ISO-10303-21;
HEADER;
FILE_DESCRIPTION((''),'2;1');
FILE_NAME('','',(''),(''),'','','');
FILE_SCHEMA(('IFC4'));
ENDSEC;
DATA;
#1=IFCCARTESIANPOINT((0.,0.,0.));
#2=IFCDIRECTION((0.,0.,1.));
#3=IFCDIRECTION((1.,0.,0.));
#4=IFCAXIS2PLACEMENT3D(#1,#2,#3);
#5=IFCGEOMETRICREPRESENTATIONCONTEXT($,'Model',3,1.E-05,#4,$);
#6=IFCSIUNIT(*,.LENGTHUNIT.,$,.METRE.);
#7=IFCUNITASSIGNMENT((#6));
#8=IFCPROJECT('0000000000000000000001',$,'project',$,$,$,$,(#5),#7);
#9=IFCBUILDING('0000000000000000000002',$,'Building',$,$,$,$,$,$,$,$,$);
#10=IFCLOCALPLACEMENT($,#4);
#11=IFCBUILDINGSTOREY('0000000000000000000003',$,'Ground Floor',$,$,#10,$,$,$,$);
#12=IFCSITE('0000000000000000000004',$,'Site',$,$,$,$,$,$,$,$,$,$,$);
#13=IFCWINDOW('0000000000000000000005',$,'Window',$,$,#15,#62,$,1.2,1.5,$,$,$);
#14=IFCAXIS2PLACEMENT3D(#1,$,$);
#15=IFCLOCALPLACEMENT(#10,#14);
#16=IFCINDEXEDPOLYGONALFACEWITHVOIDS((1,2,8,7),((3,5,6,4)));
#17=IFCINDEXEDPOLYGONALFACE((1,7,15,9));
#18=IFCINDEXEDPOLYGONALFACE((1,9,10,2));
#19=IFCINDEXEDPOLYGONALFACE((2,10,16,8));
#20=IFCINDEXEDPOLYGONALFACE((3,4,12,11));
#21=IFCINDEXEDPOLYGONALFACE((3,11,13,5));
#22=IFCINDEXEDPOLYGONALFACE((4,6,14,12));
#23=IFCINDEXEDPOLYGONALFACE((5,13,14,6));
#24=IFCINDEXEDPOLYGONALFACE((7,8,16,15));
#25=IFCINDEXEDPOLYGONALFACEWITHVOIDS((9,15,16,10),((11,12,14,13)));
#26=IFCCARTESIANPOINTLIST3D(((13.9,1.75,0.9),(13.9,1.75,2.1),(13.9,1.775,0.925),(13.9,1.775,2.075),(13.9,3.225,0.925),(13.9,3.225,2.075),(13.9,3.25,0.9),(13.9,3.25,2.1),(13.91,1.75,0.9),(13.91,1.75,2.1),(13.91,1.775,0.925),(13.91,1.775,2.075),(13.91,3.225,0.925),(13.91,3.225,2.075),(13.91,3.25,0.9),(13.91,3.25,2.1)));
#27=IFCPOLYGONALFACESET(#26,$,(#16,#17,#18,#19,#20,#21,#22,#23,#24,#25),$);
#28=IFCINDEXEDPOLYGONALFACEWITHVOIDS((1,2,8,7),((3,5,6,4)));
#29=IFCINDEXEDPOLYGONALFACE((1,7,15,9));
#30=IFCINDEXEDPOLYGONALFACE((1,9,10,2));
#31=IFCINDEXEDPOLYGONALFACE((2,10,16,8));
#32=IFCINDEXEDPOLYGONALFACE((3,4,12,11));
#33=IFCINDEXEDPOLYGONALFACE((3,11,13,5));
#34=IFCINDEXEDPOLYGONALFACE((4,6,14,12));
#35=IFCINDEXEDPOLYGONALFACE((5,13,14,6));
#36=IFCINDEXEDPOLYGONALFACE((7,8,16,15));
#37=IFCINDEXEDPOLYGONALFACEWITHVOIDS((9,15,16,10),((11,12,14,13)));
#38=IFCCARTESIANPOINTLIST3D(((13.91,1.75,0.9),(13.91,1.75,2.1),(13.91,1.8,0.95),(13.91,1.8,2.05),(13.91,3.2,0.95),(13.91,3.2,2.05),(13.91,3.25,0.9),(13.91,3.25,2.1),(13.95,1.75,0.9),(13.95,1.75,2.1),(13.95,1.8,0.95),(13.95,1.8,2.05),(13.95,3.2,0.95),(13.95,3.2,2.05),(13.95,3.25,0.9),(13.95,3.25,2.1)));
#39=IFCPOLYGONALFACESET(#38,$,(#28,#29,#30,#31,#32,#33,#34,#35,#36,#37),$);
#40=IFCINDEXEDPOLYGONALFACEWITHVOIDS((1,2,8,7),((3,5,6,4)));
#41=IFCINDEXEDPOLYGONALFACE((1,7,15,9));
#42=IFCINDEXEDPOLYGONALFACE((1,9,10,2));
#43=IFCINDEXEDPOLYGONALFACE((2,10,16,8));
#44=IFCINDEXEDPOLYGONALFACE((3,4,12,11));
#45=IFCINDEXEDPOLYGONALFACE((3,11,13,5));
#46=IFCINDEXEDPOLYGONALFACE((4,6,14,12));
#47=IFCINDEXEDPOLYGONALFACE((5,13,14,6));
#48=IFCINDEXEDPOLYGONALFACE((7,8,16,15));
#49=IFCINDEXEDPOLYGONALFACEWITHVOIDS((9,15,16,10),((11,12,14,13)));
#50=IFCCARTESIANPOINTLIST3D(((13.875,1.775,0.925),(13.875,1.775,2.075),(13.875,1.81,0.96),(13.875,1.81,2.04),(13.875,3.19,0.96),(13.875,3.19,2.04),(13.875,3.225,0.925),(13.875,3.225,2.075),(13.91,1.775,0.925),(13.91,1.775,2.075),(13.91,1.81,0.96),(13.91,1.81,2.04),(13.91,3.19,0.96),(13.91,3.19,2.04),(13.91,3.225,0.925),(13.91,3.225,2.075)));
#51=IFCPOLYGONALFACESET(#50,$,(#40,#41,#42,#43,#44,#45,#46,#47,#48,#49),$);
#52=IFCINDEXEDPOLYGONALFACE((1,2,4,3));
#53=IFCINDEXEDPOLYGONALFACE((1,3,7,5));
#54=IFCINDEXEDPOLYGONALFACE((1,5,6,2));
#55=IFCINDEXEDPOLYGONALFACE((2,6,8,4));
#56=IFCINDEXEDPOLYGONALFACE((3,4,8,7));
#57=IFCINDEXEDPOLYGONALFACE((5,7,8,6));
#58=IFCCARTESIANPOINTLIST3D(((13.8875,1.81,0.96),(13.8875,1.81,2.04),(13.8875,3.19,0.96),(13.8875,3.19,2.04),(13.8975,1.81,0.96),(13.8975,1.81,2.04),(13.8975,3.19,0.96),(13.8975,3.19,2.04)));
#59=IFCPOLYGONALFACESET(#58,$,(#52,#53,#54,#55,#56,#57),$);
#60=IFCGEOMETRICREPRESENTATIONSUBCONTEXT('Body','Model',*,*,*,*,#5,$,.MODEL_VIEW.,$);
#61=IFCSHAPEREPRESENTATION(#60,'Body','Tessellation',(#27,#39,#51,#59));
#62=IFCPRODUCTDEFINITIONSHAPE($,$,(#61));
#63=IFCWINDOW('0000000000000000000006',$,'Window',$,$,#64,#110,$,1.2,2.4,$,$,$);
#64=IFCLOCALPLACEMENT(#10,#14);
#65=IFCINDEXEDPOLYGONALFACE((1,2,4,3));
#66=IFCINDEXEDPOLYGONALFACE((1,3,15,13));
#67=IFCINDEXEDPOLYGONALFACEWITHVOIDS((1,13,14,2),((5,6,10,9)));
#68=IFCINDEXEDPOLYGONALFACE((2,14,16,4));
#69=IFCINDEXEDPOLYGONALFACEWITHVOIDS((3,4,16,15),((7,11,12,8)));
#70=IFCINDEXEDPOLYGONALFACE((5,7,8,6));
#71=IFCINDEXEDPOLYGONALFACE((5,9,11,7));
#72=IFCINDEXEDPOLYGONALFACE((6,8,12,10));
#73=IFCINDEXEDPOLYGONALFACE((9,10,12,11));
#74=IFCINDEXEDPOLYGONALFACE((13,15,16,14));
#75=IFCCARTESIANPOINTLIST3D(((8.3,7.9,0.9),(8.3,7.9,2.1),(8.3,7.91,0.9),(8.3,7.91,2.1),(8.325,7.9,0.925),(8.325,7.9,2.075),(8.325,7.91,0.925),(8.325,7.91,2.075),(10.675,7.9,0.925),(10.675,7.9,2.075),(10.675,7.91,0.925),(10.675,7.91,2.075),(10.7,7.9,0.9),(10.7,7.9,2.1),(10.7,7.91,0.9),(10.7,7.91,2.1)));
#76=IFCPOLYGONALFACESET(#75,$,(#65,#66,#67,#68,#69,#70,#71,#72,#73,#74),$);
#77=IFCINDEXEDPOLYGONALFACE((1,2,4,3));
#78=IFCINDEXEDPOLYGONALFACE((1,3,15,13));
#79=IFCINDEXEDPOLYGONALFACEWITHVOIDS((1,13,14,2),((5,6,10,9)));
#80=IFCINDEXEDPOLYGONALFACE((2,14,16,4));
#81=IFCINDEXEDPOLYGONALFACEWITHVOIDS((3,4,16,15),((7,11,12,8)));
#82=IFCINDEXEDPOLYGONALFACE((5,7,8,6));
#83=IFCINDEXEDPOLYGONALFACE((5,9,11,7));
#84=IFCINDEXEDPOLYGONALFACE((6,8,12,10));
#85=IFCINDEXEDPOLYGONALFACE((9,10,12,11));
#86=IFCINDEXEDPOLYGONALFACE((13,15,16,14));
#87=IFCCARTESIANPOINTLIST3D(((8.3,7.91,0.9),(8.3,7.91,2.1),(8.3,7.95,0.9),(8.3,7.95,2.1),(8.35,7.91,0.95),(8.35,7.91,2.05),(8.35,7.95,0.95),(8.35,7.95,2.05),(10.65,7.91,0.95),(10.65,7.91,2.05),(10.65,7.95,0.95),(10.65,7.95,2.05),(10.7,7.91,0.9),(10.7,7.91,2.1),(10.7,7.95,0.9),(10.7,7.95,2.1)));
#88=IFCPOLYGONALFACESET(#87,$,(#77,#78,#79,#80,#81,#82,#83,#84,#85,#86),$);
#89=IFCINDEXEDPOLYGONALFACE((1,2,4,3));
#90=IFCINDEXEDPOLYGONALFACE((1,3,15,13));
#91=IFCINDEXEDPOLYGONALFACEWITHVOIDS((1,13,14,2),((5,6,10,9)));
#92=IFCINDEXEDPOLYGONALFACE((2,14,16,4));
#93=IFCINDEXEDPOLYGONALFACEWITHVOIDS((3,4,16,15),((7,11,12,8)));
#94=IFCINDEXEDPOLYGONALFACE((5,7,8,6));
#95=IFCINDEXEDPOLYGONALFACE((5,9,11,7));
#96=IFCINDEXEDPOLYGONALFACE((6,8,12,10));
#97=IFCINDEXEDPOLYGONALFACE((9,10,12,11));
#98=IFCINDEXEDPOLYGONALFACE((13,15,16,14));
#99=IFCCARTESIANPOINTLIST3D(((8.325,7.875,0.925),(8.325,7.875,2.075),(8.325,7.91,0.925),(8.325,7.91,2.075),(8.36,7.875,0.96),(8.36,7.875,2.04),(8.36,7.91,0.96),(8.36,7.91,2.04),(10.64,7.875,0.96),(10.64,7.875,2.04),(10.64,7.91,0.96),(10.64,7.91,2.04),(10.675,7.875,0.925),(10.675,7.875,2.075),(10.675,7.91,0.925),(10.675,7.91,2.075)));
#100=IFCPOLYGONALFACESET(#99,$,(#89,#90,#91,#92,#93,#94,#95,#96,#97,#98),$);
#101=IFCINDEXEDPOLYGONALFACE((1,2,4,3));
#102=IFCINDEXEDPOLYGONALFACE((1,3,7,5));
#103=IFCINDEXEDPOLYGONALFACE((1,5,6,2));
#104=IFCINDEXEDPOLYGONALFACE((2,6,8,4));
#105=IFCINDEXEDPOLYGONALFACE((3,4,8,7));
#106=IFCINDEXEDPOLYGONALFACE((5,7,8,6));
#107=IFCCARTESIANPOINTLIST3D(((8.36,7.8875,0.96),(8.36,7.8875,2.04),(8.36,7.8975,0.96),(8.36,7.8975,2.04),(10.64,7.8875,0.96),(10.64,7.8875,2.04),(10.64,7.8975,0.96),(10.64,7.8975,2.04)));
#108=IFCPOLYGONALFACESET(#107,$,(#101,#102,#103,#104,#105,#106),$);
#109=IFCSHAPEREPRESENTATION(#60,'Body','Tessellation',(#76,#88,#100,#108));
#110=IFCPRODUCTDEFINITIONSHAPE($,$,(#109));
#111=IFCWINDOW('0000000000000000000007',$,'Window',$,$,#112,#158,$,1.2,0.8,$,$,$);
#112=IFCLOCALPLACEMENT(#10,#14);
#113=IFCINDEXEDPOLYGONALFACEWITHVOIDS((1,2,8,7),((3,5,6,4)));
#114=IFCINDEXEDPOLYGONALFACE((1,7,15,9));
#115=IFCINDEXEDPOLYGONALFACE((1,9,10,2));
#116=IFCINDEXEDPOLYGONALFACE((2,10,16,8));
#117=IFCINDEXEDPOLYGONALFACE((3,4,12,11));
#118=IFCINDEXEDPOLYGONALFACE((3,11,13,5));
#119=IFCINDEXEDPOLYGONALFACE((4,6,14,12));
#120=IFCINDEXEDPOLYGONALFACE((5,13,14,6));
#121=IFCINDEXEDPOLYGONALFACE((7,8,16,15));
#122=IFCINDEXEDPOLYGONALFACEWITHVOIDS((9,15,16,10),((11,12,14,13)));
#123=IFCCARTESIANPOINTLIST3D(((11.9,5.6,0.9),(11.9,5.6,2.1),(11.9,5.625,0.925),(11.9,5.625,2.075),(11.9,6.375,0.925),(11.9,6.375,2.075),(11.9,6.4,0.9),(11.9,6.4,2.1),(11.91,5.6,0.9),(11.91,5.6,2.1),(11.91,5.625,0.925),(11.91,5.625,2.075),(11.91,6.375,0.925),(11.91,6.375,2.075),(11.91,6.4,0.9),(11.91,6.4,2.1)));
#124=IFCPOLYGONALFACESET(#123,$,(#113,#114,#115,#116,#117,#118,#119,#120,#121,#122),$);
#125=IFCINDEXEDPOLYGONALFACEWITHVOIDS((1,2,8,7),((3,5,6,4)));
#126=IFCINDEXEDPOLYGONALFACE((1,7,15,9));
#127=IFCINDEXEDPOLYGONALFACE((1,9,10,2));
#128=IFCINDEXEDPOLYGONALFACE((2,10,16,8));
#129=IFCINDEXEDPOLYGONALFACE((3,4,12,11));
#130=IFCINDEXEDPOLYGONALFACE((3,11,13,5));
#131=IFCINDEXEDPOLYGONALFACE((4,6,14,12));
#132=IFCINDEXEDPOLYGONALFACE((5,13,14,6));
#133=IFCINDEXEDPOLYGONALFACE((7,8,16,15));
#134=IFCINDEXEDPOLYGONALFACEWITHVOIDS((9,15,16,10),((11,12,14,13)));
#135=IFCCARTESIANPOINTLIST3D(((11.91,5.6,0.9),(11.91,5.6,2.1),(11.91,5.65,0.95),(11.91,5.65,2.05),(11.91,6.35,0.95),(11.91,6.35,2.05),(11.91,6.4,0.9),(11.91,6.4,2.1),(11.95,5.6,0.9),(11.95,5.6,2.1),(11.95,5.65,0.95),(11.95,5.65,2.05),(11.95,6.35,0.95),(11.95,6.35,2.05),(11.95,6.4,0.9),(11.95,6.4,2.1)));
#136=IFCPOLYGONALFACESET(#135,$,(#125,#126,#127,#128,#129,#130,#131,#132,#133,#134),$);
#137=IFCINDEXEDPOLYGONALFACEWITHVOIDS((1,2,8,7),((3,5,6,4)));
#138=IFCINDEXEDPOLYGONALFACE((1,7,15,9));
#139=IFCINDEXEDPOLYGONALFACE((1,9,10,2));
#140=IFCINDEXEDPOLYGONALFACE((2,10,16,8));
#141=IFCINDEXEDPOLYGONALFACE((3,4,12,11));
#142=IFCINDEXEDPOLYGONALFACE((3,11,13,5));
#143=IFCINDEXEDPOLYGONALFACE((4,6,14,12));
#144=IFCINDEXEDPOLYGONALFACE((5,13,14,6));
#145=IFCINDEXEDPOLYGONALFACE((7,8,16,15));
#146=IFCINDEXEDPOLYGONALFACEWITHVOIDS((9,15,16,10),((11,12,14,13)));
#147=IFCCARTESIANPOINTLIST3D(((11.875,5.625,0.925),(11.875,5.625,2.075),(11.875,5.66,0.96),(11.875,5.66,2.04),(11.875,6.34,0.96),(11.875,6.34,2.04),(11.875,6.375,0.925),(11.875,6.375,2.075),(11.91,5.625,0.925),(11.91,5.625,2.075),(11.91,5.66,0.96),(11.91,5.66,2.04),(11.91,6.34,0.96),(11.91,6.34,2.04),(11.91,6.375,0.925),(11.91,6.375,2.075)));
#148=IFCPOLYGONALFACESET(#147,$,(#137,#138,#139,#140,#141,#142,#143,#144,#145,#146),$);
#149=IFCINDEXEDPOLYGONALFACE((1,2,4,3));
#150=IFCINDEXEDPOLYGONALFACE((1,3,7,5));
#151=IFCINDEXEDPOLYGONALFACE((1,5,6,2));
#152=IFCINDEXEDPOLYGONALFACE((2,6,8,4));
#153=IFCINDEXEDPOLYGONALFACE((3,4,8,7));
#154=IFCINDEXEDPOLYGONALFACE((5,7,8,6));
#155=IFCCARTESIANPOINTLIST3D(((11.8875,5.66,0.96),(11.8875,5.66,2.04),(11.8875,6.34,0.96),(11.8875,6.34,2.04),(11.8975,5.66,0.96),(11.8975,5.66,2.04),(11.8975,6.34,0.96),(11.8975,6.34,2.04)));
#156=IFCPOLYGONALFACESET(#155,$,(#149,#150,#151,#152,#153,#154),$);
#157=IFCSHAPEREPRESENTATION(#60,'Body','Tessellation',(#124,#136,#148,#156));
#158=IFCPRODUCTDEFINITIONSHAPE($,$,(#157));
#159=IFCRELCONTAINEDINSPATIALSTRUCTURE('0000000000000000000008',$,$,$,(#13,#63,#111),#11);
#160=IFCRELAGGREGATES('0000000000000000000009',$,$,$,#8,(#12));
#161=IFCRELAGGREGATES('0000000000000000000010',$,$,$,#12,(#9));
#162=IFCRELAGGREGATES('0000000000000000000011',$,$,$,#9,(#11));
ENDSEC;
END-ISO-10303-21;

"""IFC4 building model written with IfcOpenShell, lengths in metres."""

from ifc_helpers import new_model, si_unit, frame, origin_with_axes, place, context, subcontext, project, spatial, line, indexed_curve, outline, extrude, element, save


model = new_model("IFC4")

# Units and contexts
model_context = context("Model", 3, precision=1e-05, world=origin_with_axes())
body_context = subcontext(model_context, "Body", "Model", "MODEL_VIEW")
ifc_project = project(units=[si_unit("LENGTHUNIT", "METRE")], contexts=[model_context])

# Site, building, storey
site = spatial("IfcSite", under=ifc_project, Name="Site")
building = spatial("IfcBuilding", under=site, Name="Building")
storey_placement = place(None, origin_with_axes())
storey = spatial("IfcBuildingStorey", under=building, at=storey_placement, Name="Ground Floor")

# Windows
window_1_placement = place(storey_placement, frame((14.0, 1.75, 0.9), z_axis=(0.0, 0.0, 1.0), x_axis=(0.0, 1.0, 0.0)))
element("IfcWindow", 1, at=window_1_placement, inside=storey, Name="Window", OverallHeight=1.2, OverallWidth=1.5, context=body_context, shape_type="SweptSolid", body=[
    extrude(outline(indexed_curve([(0.0, 0.0), (1.5, 0.0), (1.5, 1.2), (0.0, 1.2)], segments=[line(1, 2, 3, 4, 1)]), holes=[indexed_curve([(0.025, 0.025), (1.475, 0.025), (1.475, 1.175), (0.025, 1.175)], segments=[line(1, 2, 3, 4, 1)])]), frame((0.0, 0.09, 0.0), z_axis=(0.0, -1.0, 0.0), x_axis=(1.0, 0.0, 0.0)), (0.0, 0.0, -1.0), 0.01),
    extrude(outline(indexed_curve([(0.0, 0.0), (1.5, 0.0), (1.5, 1.2), (0.0, 1.2)], segments=[line(1, 2, 3, 4, 1)]), holes=[indexed_curve([(0.05, 0.05), (1.45, 0.05), (1.45, 1.15), (0.05, 1.15)], segments=[line(1, 2, 3, 4, 1)])]), frame((0.0, 0.05, 0.0), z_axis=(0.0, -1.0, 0.0), x_axis=(1.0, 0.0, 0.0)), (0.0, 0.0, -1.0), 0.04),
    extrude(outline(indexed_curve([(0.0, 0.0), (1.45, 0.0), (1.45, 1.15), (0.0, 1.15)], segments=[line(1, 2, 3, 4, 1)]), holes=[indexed_curve([(0.035, 0.035), (1.415, 0.035), (1.415, 1.115), (0.035, 1.115)], segments=[line(1, 2, 3, 4, 1)])]), frame((0.025, 0.09, 0.025), z_axis=(0.0, -1.0, 0.0), x_axis=(1.0, 0.0, 0.0)), (0.0, 0.0, -1.0), 0.035),
    extrude(outline(indexed_curve([(0.035, 0.035), (1.415, 0.035), (1.415, 1.115), (0.035, 1.115)], segments=[line(1, 2, 3, 4, 1)])), frame((0.025, 0.1025, 0.025), z_axis=(0.0, -1.0, 0.0), x_axis=(1.0, 0.0, 0.0)), (0.0, 0.0, -1.0), 0.01),
])
window_2_placement = place(storey_placement, frame((10.7, 8.0, 0.9), z_axis=(0.0, 0.0, 1.0), x_axis=(-1.0, 0.0, 0.0)))
element("IfcWindow", 2, at=window_2_placement, inside=storey, Name="Window", OverallHeight=1.2, OverallWidth=2.4, context=body_context, shape_type="SweptSolid", body=[
    extrude(outline(indexed_curve([(0.0, 0.0), (2.4, 0.0), (2.4, 1.2), (0.0, 1.2)], segments=[line(1, 2, 3, 4, 1)]), holes=[indexed_curve([(0.025, 0.025), (2.375, 0.025), (2.375, 1.175), (0.025, 1.175)], segments=[line(1, 2, 3, 4, 1)])]), frame((0.0, 0.09, 0.0), z_axis=(0.0, -1.0, 0.0), x_axis=(1.0, 0.0, 0.0)), (0.0, 0.0, -1.0), 0.01),
    extrude(outline(indexed_curve([(0.0, 0.0), (2.4, 0.0), (2.4, 1.2), (0.0, 1.2)], segments=[line(1, 2, 3, 4, 1)]), holes=[indexed_curve([(0.05, 0.05), (2.35, 0.05), (2.35, 1.15), (0.05, 1.15)], segments=[line(1, 2, 3, 4, 1)])]), frame((0.0, 0.05, 0.0), z_axis=(0.0, -1.0, 0.0), x_axis=(1.0, 0.0, 0.0)), (0.0, 0.0, -1.0), 0.04),
    extrude(outline(indexed_curve([(0.0, 0.0), (2.35, 0.0), (2.35, 1.15), (0.0, 1.15)], segments=[line(1, 2, 3, 4, 1)]), holes=[indexed_curve([(0.035, 0.035), (2.315, 0.035), (2.315, 1.115), (0.035, 1.115)], segments=[line(1, 2, 3, 4, 1)])]), frame((0.025, 0.09, 0.025), z_axis=(0.0, -1.0, 0.0), x_axis=(1.0, 0.0, 0.0)), (0.0, 0.0, -1.0), 0.035),
    extrude(outline(indexed_curve([(0.035, 0.035), (2.315, 0.035), (2.315, 1.115), (0.035, 1.115)], segments=[line(1, 2, 3, 4, 1)])), frame((0.025, 0.1025, 0.025), z_axis=(0.0, -1.0, 0.0), x_axis=(1.0, 0.0, 0.0)), (0.0, 0.0, -1.0), 0.01),
])
window_3_placement = place(storey_placement, frame((12.0, 5.6, 0.9), z_axis=(0.0, 0.0, 1.0), x_axis=(0.0, 1.0, 0.0)))
element("IfcWindow", 3, at=window_3_placement, inside=storey, Name="Window", OverallHeight=1.2, OverallWidth=0.8, context=body_context, shape_type="SweptSolid", body=[
    extrude(outline(indexed_curve([(0.0, 0.0), (0.8, 0.0), (0.8, 1.2), (0.0, 1.2)], segments=[line(1, 2, 3, 4, 1)]), holes=[indexed_curve([(0.025, 0.025), (0.775, 0.025), (0.775, 1.175), (0.025, 1.175)], segments=[line(1, 2, 3, 4, 1)])]), frame((0.0, 0.09, 0.0), z_axis=(0.0, -1.0, 0.0), x_axis=(1.0, 0.0, 0.0)), (0.0, 0.0, -1.0), 0.01),
    extrude(outline(indexed_curve([(0.0, 0.0), (0.8, 0.0), (0.8, 1.2), (0.0, 1.2)], segments=[line(1, 2, 3, 4, 1)]), holes=[indexed_curve([(0.05, 0.05), (0.75, 0.05), (0.75, 1.15), (0.05, 1.15)], segments=[line(1, 2, 3, 4, 1)])]), frame((0.0, 0.05, 0.0), z_axis=(0.0, -1.0, 0.0), x_axis=(1.0, 0.0, 0.0)), (0.0, 0.0, -1.0), 0.04),
    extrude(outline(indexed_curve([(0.0, 0.0), (0.75, 0.0), (0.75, 1.15), (0.0, 1.15)], segments=[line(1, 2, 3, 4, 1)]), holes=[indexed_curve([(0.035, 0.035), (0.715, 0.035), (0.715, 1.115), (0.035, 1.115)], segments=[line(1, 2, 3, 4, 1)])]), frame((0.025, 0.09, 0.025), z_axis=(0.0, -1.0, 0.0), x_axis=(1.0, 0.0, 0.0)), (0.0, 0.0, -1.0), 0.035),
    extrude(outline(indexed_curve([(0.035, 0.035), (0.715, 0.035), (0.715, 1.115), (0.035, 1.115)], segments=[line(1, 2, 3, 4, 1)])), frame((0.025, 0.1025, 0.025), z_axis=(0.0, -1.0, 0.0), x_axis=(1.0, 0.0, 0.0)), (0.0, 0.0, -1.0), 0.01),
])

save(model, "model.ifc")
